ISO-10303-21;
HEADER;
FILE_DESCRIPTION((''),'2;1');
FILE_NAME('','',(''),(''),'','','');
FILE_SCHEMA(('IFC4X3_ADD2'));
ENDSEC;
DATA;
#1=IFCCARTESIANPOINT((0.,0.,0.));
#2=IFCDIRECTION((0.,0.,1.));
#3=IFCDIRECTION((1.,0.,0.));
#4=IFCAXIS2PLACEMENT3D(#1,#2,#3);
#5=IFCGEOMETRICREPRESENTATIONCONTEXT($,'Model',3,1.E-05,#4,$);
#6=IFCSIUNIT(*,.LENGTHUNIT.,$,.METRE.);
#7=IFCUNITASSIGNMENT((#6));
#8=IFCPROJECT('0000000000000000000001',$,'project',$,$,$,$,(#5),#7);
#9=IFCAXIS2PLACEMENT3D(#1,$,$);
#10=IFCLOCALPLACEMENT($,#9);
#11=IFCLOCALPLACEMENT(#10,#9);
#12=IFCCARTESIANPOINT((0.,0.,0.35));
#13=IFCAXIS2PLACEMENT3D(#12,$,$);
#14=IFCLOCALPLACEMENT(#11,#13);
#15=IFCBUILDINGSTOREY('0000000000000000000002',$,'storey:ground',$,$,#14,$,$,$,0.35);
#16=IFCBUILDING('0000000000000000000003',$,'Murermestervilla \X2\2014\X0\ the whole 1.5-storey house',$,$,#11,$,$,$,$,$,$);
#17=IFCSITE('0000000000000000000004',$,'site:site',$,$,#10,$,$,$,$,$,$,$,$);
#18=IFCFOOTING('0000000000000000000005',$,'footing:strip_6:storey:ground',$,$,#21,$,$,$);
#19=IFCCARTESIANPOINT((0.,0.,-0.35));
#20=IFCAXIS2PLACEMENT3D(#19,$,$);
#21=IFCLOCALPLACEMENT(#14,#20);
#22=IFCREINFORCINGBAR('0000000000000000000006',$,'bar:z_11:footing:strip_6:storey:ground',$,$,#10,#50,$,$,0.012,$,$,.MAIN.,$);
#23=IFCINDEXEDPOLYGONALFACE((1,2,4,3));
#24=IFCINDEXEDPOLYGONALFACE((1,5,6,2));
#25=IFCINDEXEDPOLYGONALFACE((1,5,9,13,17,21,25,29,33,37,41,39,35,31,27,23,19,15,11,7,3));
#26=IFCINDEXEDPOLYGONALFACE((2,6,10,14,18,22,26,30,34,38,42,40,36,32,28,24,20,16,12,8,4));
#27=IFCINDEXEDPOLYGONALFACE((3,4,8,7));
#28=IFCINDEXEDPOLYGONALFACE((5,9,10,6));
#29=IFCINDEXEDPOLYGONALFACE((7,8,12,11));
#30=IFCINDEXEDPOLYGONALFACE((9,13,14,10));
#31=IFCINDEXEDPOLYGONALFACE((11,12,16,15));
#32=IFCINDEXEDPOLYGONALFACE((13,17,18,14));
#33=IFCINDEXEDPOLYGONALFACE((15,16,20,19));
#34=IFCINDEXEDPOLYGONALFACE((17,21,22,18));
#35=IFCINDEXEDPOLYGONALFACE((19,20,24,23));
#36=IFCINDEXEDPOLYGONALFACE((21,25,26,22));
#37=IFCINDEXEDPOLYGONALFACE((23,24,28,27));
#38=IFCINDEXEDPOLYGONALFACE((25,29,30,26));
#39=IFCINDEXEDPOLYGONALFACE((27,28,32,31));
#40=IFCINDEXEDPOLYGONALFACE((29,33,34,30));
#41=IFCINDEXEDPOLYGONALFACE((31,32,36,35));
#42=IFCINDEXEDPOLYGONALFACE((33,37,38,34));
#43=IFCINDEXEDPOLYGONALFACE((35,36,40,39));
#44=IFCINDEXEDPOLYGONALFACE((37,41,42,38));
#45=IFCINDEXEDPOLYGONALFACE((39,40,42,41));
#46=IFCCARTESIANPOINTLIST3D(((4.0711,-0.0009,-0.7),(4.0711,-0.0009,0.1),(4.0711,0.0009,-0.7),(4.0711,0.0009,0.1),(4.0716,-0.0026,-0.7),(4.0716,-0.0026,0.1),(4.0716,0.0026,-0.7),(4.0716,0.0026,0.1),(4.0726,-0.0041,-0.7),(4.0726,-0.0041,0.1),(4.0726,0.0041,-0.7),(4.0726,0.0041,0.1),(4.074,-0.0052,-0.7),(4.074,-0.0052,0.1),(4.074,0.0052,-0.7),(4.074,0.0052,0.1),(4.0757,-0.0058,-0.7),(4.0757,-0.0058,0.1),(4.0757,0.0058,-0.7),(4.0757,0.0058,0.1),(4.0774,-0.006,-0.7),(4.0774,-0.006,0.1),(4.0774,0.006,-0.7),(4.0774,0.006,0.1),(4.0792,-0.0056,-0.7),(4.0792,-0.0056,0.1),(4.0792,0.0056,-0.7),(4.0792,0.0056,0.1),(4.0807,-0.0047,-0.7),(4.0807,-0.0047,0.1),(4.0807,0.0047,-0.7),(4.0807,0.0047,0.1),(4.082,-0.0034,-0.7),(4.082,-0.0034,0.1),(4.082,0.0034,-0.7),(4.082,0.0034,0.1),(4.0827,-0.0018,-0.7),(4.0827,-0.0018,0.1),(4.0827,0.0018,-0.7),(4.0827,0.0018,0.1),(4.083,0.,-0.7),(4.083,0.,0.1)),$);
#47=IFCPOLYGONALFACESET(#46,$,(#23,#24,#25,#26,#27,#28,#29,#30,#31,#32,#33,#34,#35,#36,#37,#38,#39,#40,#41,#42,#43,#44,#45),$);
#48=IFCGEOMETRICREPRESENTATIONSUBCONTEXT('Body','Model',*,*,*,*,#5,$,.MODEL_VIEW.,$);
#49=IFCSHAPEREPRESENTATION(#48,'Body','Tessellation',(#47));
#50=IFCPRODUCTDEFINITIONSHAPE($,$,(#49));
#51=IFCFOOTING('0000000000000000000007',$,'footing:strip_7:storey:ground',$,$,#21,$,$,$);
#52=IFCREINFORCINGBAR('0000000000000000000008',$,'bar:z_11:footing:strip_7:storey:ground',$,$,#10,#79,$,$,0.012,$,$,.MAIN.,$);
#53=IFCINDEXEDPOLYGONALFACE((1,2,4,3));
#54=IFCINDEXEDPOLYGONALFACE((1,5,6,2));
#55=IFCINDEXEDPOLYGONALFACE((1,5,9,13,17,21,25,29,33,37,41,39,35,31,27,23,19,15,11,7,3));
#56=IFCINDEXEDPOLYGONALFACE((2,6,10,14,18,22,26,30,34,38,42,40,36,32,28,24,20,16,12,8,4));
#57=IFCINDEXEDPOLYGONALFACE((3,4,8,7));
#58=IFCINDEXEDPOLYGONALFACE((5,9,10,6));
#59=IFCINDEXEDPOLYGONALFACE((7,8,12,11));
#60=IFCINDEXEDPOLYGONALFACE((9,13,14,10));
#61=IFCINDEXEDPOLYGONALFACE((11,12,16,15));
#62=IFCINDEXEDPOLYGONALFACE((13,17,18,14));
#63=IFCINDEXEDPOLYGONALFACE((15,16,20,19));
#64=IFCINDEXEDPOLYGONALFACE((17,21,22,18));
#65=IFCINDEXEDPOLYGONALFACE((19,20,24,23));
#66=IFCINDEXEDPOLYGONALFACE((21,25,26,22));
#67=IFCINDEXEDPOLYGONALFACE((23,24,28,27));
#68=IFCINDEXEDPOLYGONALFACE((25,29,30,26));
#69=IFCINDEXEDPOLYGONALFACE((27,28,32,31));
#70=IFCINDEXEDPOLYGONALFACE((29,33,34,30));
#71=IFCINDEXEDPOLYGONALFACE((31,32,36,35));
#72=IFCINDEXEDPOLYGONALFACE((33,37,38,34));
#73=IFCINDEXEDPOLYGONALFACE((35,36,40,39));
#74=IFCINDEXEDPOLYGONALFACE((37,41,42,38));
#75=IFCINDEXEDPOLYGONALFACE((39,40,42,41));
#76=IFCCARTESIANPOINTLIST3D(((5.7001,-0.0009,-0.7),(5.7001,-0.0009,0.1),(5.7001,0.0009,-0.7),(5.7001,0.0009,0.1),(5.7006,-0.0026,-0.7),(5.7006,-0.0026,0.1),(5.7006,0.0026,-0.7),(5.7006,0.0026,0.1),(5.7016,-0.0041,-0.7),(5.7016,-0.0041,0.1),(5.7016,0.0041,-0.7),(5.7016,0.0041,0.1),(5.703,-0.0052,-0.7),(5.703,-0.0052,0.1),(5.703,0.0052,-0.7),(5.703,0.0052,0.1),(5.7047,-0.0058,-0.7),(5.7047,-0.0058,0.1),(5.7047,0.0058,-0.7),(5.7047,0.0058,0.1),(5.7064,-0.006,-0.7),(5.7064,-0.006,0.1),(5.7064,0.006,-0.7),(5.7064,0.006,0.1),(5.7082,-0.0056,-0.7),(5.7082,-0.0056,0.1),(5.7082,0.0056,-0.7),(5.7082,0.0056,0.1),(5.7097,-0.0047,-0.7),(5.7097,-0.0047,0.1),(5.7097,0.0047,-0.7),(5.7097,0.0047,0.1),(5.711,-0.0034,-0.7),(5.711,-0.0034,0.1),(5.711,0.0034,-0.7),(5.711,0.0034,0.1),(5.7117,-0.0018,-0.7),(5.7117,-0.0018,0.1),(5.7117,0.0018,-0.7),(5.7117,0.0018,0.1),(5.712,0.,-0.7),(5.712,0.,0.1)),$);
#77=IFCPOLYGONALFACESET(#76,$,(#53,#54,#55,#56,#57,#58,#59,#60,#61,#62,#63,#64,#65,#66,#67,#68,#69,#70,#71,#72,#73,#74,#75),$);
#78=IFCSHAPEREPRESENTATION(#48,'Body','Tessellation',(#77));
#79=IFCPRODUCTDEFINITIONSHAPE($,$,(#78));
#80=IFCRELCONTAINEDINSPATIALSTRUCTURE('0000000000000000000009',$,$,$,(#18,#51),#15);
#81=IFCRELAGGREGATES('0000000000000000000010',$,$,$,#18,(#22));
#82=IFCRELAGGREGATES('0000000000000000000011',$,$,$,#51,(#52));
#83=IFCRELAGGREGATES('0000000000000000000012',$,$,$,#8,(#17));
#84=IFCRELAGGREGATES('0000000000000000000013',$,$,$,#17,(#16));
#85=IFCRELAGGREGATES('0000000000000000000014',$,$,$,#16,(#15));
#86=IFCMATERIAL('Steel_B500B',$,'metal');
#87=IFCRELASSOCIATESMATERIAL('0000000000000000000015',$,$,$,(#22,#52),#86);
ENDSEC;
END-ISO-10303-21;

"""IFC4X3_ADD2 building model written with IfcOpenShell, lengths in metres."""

from ifc_helpers import new_model, entity, si_unit, frame, origin, origin_with_axes, place, context, subcontext, project, spatial, material, element, aggregate, save


model = new_model("IFC4X3_ADD2")

# Units and contexts
model_context = context("Model", 3, precision=1e-05, world=origin_with_axes())
body_context = subcontext(model_context, "Body", "Model", "MODEL_VIEW")
ifc_project = project(units=[si_unit("LENGTHUNIT", "METRE")], contexts=[model_context])

# Site, building, storey
placement_1 = place(None, origin())
site = spatial("IfcSite", under=ifc_project, at=placement_1, Name="site:site")
building_placement = place(placement_1, origin())
building = spatial("IfcBuilding", under=site, at=building_placement, Name="Murermestervilla — the whole 1.5-storey house")
storey_placement = place(building_placement, frame((0.0, 0.0, 0.35)))
storey = spatial("IfcBuildingStorey", under=building, at=storey_placement, Name="storey:ground", Elevation=0.35)

# Footings, reinforcing bars
placement_2 = place(storey_placement, frame((0.0, 0.0, -0.35)))
footing_1 = element("IfcFooting", 1, at=placement_2, inside=storey, Name="footing:strip_6:storey:ground")
ifc_material = material(Name="Steel_B500B", Category="metal")
reinforcing_bar_1 = element("IfcReinforcingBar", 2, at=placement_1, material=ifc_material, Name="bar:z_11:footing:strip_6:storey:ground", NominalDiameter=0.012, PredefinedType="MAIN", context=body_context, shape_type="AdvancedSweptSolid", body=[
    entity("IfcSweptDiskSolid", entity("IfcPolyline", [entity("IfcCartesianPoint", [4.077, 0.0, -0.7]), entity("IfcCartesianPoint", [4.077, 0.0, 0.1])]), 0.006),
])
aggregate(footing_1, [reinforcing_bar_1])
footing_2 = element("IfcFooting", 3, at=placement_2, inside=storey, Name="footing:strip_7:storey:ground")
reinforcing_bar_2 = element("IfcReinforcingBar", 4, at=placement_1, material=ifc_material, Name="bar:z_11:footing:strip_7:storey:ground", NominalDiameter=0.012, PredefinedType="MAIN", context=body_context, shape_type="AdvancedSweptSolid", body=[
    entity("IfcSweptDiskSolid", entity("IfcPolyline", [entity("IfcCartesianPoint", [5.706, 0.0, -0.7]), entity("IfcCartesianPoint", [5.706, 0.0, 0.1])]), 0.006),
])
aggregate(footing_2, [reinforcing_bar_2])

save(model, "model.ifc")
